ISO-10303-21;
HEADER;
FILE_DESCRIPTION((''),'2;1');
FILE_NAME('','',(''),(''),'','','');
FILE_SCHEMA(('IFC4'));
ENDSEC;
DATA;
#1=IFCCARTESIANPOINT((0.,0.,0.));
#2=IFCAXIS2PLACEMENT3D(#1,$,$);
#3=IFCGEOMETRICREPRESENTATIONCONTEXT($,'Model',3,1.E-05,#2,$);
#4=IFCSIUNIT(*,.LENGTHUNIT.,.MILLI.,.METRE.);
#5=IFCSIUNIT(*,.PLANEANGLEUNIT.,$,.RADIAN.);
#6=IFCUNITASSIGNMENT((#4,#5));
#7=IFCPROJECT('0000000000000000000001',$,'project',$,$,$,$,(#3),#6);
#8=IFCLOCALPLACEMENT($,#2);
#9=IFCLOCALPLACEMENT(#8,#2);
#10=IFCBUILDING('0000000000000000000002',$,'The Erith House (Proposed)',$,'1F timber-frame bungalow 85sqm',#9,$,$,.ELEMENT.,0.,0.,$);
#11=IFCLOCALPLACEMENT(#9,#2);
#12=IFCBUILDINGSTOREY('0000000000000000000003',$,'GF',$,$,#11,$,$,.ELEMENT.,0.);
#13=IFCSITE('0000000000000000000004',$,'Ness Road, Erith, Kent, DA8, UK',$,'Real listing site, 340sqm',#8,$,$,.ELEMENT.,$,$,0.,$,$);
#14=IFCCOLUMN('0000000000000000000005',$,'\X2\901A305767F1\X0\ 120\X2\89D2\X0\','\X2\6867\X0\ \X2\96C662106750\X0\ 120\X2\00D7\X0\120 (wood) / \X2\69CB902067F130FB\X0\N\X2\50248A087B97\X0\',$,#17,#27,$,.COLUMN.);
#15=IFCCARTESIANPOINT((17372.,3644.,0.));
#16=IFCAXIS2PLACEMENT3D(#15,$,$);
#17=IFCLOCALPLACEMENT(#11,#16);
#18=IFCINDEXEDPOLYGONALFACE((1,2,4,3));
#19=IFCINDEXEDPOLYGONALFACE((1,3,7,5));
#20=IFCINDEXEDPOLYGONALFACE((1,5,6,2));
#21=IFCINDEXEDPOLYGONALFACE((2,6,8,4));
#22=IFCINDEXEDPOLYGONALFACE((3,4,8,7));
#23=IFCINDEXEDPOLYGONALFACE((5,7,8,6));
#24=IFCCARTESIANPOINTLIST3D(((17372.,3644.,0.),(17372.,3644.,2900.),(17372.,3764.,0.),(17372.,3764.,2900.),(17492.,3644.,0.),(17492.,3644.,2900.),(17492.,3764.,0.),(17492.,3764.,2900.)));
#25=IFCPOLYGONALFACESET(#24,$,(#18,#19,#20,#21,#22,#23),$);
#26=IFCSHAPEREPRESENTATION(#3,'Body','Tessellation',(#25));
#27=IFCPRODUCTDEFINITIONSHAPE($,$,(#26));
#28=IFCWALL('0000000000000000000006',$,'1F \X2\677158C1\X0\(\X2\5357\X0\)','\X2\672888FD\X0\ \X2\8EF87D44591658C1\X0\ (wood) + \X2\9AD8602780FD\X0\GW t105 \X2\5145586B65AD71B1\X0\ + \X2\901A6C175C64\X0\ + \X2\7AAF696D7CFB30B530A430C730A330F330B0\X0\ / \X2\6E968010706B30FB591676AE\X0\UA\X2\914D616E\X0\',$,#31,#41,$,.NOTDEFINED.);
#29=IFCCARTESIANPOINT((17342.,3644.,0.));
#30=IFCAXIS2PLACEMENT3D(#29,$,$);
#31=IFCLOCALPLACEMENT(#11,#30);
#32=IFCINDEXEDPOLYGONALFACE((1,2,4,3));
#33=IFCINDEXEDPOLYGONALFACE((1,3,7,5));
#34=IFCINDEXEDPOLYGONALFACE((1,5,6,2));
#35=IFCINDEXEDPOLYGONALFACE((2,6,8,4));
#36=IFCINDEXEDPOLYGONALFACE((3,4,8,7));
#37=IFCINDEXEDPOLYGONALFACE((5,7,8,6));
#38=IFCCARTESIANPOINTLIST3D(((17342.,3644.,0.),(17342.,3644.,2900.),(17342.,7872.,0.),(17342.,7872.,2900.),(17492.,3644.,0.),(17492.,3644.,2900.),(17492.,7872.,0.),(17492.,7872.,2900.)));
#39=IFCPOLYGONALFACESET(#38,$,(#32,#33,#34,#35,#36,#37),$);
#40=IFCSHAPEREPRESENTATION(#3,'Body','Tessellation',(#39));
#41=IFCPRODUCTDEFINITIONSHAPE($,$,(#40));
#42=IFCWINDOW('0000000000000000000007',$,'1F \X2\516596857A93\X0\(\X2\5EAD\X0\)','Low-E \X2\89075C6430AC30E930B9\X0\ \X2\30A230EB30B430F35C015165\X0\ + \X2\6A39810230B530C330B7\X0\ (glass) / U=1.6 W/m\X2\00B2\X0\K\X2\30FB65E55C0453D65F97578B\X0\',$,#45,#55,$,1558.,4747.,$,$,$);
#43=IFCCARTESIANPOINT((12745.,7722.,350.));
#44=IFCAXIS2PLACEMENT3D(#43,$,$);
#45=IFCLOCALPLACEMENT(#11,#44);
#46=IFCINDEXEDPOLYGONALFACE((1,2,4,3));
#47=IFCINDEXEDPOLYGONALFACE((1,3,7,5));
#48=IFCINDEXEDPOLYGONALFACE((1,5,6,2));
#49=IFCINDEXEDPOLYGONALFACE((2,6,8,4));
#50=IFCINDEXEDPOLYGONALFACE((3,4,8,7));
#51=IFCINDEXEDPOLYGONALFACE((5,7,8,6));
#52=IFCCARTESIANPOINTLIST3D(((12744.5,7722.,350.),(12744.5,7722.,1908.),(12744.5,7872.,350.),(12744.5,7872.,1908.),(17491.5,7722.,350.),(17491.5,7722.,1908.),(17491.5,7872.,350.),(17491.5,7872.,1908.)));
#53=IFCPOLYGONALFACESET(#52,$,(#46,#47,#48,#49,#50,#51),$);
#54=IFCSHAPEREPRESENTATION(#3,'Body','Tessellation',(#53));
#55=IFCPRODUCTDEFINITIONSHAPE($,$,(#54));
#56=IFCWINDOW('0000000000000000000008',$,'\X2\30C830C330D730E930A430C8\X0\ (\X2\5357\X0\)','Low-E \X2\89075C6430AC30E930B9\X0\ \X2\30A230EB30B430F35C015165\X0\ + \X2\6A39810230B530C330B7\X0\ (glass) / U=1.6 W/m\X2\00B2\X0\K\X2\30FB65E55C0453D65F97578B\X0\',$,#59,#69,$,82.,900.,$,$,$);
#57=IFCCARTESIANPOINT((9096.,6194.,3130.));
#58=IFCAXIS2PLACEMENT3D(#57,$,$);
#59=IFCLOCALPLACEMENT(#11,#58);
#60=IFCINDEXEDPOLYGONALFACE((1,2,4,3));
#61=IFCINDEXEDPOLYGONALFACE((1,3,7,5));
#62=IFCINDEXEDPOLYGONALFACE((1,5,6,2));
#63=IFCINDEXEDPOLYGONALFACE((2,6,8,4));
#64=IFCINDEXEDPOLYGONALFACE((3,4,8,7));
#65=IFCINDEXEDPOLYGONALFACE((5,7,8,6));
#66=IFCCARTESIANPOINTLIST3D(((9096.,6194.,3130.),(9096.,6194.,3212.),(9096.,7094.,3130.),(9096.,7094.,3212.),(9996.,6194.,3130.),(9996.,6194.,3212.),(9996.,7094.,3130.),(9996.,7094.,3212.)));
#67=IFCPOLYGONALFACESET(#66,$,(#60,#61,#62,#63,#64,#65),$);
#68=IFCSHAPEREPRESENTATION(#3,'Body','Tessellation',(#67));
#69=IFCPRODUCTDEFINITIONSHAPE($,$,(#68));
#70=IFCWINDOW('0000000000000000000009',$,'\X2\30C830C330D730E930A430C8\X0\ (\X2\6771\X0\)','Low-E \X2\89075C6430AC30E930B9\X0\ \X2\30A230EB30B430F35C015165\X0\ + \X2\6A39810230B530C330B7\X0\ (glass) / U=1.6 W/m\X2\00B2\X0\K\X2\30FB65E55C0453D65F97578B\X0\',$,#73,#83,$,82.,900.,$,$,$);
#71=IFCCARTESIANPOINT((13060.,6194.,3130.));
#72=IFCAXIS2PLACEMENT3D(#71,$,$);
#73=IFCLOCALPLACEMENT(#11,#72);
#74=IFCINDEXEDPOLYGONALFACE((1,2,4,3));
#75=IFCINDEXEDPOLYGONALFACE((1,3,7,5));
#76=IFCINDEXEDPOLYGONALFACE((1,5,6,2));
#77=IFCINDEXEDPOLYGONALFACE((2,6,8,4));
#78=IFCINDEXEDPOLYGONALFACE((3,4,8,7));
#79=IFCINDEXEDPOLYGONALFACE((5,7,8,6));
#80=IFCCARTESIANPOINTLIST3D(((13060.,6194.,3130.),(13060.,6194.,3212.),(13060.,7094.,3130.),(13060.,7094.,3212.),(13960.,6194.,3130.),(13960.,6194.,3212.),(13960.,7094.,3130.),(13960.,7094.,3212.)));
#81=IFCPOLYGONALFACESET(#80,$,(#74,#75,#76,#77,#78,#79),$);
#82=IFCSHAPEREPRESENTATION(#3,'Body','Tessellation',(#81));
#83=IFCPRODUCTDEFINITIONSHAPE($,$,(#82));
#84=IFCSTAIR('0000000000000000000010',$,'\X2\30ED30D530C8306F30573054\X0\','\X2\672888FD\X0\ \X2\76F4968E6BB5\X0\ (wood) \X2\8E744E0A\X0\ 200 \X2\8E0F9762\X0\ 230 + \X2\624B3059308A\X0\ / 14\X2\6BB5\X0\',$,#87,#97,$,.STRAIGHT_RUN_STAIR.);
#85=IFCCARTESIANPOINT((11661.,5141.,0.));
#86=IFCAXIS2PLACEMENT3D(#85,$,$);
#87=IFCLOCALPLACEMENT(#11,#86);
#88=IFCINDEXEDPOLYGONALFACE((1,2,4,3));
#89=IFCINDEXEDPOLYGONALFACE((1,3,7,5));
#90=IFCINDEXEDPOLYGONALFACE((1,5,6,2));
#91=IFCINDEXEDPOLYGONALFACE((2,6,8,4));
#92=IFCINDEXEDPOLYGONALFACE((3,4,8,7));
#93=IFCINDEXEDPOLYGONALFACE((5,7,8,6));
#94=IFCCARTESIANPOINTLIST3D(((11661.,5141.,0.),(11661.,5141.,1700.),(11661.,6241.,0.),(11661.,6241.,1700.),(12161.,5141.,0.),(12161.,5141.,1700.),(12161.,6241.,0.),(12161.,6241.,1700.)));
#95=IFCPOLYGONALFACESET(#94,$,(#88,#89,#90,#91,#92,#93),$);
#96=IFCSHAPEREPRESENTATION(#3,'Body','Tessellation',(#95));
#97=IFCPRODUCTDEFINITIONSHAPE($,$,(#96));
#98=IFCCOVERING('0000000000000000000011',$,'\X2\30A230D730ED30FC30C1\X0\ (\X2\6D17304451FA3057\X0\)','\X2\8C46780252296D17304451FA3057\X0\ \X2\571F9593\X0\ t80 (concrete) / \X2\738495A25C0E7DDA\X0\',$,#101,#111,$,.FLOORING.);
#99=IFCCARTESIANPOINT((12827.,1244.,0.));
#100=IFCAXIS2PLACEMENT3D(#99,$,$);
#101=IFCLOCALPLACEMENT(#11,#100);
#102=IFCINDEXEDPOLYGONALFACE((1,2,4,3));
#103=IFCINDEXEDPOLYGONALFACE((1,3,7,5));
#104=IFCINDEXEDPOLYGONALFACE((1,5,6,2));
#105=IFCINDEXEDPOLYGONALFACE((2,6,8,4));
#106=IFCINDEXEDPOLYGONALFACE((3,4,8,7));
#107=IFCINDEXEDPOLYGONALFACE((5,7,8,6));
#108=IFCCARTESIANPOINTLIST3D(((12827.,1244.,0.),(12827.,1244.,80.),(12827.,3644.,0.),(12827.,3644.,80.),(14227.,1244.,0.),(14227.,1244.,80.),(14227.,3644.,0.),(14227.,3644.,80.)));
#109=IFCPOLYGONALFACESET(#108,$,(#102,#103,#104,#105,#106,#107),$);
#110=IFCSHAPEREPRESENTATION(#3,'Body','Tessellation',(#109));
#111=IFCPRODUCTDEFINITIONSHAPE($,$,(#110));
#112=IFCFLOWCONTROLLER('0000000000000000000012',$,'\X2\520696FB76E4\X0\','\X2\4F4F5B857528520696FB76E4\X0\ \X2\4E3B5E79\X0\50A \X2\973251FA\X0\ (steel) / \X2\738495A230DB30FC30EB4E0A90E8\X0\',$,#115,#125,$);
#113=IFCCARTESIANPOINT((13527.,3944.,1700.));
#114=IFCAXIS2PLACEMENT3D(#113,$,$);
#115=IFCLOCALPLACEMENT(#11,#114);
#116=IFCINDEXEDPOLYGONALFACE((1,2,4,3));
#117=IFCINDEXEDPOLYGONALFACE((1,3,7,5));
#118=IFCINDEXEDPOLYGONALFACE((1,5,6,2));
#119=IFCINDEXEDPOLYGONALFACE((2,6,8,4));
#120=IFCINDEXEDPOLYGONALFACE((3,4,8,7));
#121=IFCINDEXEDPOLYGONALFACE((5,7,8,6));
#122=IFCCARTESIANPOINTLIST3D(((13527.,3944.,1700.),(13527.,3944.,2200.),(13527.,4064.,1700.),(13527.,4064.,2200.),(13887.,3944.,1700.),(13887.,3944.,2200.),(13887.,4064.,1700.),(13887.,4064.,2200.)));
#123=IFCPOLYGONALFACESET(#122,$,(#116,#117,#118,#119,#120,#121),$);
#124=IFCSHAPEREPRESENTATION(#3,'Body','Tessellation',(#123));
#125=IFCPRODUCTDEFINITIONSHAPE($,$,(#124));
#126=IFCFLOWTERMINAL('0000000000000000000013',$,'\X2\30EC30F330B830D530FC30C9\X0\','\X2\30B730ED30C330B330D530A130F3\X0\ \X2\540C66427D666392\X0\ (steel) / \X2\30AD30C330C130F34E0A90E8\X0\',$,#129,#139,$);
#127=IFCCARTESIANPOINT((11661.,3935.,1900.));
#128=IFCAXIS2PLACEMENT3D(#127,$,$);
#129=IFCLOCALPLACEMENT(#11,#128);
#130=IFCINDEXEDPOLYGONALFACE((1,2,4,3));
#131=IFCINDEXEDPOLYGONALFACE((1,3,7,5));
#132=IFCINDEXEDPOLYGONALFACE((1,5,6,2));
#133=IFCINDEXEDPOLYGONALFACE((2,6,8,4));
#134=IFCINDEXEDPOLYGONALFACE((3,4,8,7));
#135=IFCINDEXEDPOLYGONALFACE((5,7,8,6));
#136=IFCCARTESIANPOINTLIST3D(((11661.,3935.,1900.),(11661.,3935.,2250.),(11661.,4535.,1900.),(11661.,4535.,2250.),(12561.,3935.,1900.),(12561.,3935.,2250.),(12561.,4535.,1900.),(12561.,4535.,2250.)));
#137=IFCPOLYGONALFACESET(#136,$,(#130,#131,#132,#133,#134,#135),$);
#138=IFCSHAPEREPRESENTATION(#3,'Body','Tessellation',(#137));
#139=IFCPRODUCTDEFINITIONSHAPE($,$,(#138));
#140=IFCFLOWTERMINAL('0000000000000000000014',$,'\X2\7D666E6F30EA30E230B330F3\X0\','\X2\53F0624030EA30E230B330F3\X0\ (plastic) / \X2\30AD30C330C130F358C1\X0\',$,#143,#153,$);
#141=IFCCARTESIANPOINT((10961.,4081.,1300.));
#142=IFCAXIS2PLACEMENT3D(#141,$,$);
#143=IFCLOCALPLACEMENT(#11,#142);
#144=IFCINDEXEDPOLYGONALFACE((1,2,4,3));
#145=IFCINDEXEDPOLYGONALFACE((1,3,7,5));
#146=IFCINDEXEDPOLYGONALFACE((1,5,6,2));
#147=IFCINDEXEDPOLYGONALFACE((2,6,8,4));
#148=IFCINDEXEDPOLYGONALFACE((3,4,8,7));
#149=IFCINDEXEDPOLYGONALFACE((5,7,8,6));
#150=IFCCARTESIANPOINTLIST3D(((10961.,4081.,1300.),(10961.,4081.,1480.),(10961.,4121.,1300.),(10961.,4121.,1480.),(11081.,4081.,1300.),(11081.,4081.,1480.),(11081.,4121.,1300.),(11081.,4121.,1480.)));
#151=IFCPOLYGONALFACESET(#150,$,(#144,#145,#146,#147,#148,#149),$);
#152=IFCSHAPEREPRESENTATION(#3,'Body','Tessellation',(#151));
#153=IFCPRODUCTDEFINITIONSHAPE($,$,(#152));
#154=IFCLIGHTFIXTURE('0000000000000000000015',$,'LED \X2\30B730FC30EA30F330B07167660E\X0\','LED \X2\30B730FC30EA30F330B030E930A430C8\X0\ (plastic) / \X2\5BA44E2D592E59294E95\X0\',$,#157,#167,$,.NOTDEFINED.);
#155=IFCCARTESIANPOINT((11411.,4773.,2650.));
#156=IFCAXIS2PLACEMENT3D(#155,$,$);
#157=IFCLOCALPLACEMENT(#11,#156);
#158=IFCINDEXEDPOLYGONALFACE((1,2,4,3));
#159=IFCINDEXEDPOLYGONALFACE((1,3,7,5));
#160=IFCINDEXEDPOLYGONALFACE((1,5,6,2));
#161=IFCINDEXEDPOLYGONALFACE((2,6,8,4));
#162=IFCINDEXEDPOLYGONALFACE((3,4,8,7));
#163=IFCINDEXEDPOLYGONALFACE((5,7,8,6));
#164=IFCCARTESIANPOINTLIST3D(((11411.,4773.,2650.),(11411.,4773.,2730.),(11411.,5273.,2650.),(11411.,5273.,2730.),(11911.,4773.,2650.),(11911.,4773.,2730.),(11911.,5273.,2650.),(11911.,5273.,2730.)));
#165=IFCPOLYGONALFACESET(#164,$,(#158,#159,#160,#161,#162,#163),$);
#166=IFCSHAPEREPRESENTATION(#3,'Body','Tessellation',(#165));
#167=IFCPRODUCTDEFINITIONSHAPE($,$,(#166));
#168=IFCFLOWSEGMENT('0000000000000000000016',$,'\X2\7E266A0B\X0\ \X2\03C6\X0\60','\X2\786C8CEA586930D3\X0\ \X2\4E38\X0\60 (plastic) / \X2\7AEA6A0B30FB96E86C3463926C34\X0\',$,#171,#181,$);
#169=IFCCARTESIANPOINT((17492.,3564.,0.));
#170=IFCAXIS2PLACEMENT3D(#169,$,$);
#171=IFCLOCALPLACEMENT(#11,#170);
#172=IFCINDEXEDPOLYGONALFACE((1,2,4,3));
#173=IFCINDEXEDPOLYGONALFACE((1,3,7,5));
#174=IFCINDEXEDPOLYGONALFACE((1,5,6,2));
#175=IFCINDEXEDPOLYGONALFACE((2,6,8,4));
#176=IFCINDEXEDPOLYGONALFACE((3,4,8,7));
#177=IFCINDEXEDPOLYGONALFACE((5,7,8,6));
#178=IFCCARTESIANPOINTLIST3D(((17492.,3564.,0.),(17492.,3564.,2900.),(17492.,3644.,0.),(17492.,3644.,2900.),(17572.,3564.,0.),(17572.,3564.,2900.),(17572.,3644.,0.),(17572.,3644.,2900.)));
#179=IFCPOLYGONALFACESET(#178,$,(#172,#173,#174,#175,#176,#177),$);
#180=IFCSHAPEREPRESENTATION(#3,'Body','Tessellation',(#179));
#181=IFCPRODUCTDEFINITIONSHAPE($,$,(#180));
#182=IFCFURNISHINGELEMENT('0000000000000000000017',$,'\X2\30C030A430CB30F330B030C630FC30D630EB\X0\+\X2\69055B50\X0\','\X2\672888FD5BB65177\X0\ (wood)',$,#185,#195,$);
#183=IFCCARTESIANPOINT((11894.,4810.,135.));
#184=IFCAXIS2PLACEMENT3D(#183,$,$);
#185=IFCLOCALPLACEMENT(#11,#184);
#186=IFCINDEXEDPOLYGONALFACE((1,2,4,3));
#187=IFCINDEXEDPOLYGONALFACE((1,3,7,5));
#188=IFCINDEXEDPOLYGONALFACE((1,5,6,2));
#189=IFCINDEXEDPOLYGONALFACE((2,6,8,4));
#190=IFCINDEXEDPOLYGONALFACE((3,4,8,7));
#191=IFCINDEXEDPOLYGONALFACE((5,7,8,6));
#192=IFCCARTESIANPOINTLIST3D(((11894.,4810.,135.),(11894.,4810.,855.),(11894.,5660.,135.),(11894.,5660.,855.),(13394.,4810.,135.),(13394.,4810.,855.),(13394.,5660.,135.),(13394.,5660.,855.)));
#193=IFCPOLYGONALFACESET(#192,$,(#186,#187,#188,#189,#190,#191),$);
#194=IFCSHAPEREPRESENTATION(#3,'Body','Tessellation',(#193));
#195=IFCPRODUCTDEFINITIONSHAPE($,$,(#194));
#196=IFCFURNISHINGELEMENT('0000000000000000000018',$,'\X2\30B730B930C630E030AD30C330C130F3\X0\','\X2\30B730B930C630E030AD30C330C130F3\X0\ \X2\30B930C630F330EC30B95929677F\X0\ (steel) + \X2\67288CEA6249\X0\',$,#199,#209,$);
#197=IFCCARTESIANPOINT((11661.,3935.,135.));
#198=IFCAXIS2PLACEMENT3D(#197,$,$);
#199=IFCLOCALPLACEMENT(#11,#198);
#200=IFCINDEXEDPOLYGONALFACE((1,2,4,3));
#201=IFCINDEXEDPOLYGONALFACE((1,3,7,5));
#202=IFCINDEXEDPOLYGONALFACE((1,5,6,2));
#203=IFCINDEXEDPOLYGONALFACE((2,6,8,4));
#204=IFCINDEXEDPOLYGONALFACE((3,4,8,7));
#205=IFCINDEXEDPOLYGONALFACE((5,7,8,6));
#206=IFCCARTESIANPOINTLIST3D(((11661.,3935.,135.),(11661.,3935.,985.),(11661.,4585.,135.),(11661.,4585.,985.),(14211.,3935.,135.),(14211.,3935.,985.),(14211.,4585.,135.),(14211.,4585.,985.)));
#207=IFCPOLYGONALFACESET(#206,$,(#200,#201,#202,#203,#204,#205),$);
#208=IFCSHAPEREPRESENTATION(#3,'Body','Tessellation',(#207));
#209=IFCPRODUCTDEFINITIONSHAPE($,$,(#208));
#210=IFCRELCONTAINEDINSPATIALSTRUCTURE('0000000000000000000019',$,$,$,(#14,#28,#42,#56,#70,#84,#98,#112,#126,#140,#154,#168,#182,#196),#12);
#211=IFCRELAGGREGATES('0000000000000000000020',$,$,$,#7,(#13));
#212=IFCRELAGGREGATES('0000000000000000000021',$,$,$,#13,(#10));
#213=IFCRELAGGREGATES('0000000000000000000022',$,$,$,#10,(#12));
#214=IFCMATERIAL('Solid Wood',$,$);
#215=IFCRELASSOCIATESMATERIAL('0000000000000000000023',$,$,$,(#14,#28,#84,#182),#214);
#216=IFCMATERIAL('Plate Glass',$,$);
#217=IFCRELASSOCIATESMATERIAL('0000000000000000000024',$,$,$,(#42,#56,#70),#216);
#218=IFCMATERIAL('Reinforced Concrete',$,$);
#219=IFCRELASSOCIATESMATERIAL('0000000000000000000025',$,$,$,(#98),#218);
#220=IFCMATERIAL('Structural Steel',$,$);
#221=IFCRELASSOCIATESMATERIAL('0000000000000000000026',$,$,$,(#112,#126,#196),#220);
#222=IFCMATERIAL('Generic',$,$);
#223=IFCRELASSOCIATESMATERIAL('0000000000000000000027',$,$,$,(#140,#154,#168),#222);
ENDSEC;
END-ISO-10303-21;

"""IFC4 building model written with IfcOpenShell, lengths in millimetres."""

from ifc_helpers import new_model, si_unit, frame, frame_2d, origin, place, context, project, spatial, rectangle, extrude, material, element, fill, save


model = new_model("IFC4")

# Units and contexts
model_context = context("Model", 3, precision=1e-05, world=origin())
ifc_project = project(units=[si_unit("LENGTHUNIT", "METRE", prefix="MILLI"), si_unit("PLANEANGLEUNIT", "RADIAN")], contexts=[model_context])

# Site, building, storey
site_placement = place(None, origin())
site = spatial("IfcSite", under=ifc_project, at=site_placement, Name="Ness Road, Erith, Kent, DA8, UK", ObjectType="Real listing site, 340sqm", CompositionType="ELEMENT", RefElevation=0.0)
building_placement = place(site_placement, origin())
building = spatial("IfcBuilding", under=site, at=building_placement, Name="The Erith House (Proposed)", ObjectType="1F timber-frame bungalow 85sqm", CompositionType="ELEMENT", ElevationOfRefHeight=0.0, ElevationOfTerrain=0.0)
storey_placement = place(building_placement, origin())
storey = spatial("IfcBuildingStorey", under=building, at=storey_placement, Name="GF", CompositionType="ELEMENT", Elevation=0.0)

# Column
ifc_material_1 = material(Name="Solid Wood")
column_1_placement = place(storey_placement, frame((17372.0, 3644.0, 0.0)))
element("IfcColumn", 1, at=column_1_placement, inside=storey, material=ifc_material_1, Name="通し柱 120角", Description="桧 集成材 120×120 (wood) / 構造柱・N値計算", PredefinedType="COLUMN", context=model_context, shape_type="SweptSolid", body=[
    extrude(rectangle(XDim=120.0, YDim=120.0, at=frame_2d((60.0, 60.0))), frame((17372.0, 3644.0, 0.0)), (0.0, 0.0, 1.0), 2900.0),
])

# Wall, opening, window
wall_1_placement = place(storey_placement, frame((17342.0, 3644.0, 0.0)))
wall_1 = element("IfcWall", 2, at=wall_1_placement, inside=storey, material=ifc_material_1, Name="1F 東壁(南)", Description="木製 軸組外壁 (wood) + 高性能GW t105 充填断熱 + 通気層 + 窯業系サイディング / 準耐火・外皮UA配慮", PredefinedType="NOTDEFINED", context=model_context, shape_type="SweptSolid", body=[
    extrude(rectangle(XDim=150.0, YDim=4228.0, at=frame_2d((75.0, 2114.0))), frame((17342.0, 3644.0, 0.0)), (0.0, 0.0, 1.0), 2900.0),
])
opening_1_placement = place(storey_placement, frame((12745.0, 7722.0, 350.0)))
opening_1 = element("IfcOpeningElement", 3, at=opening_1_placement, cuts=wall_1, PredefinedType="NOTDEFINED", context=model_context, shape_type="SweptSolid", body=[
    extrude(rectangle(XDim=4747.0, YDim=150.0, at=frame_2d((2373.0, 75.0))), frame((12745.0, 7722.0, 350.0)), (0.0, 0.0, 1.0), 1558.0),
])
ifc_material_2 = material(Name="Plate Glass")
window_1_placement = place(storey_placement, frame((12745.0, 7722.0, 350.0)))
window_1 = element("IfcWindow", 4, at=window_1_placement, inside=storey, material=ifc_material_2, Name="1F 入隅窓(庭)", Description="Low-E 複層ガラス アルゴン封入 + 樹脂サッシ (glass) / U=1.6 W/m²K・日射取得型", OverallHeight=1558.0, OverallWidth=4747.0, context=model_context, shape_type="SweptSolid", body=[
    extrude(rectangle(XDim=4747.0, YDim=150.0, at=frame_2d((2373.0, 75.0))), frame((12745.0, 7722.0, 350.0)), (0.0, 0.0, 1.0), 1558.0),
])
fill(opening_1, window_1)

# Windows
window_2_placement = place(storey_placement, frame((9096.0, 6194.0, 3130.0)))
element("IfcWindow", 5, at=window_2_placement, inside=storey, material=ifc_material_2, Name="トップライト (南)", Description="Low-E 複層ガラス アルゴン封入 + 樹脂サッシ (glass) / U=1.6 W/m²K・日射取得型", OverallHeight=82.0, OverallWidth=900.0, context=model_context, shape_type="SweptSolid", body=[
    extrude(rectangle(XDim=900.0, YDim=900.0, at=frame_2d((450.0, 450.0))), frame((9096.0, 6194.0, 3130.0)), (0.0, 0.0, 1.0), 82.0),
])
window_3_placement = place(storey_placement, frame((13060.0, 6194.0, 3130.0)))
element("IfcWindow", 6, at=window_3_placement, inside=storey, material=ifc_material_2, Name="トップライト (東)", Description="Low-E 複層ガラス アルゴン封入 + 樹脂サッシ (glass) / U=1.6 W/m²K・日射取得型", OverallHeight=82.0, OverallWidth=900.0, context=model_context, shape_type="SweptSolid", body=[
    extrude(rectangle(XDim=900.0, YDim=900.0, at=frame_2d((450.0, 450.0))), frame((13060.0, 6194.0, 3130.0)), (0.0, 0.0, 1.0), 82.0),
])

# Stair
stair_placement = place(storey_placement, frame((11661.0, 5141.0, 0.0)))
element("IfcStair", 7, at=stair_placement, inside=storey, material=ifc_material_1, Name="ロフトはしご", Description="木製 直階段 (wood) 蹴上 200 踏面 230 + 手すり / 14段", PredefinedType="STRAIGHT_RUN_STAIR", context=model_context, shape_type="SweptSolid", body=[
    extrude(rectangle(XDim=500.0, YDim=1100.0, at=frame_2d((250.0, 550.0))), frame((11661.0, 5141.0, 0.0)), (0.0, 0.0, 1.0), 1700.0),
])

# Covering
ifc_material_3 = material(Name="Reinforced Concrete")
covering_placement = place(storey_placement, frame((12827.0, 1244.0, 0.0)))
element("IfcCovering", 8, at=covering_placement, inside=storey, material=ifc_material_3, Name="アプローチ (洗い出し)", Description="豆砂利洗い出し 土間 t80 (concrete) / 玄関導線", PredefinedType="FLOORING", context=model_context, shape_type="SweptSolid", body=[
    extrude(rectangle(XDim=1400.0, YDim=2400.0, at=frame_2d((700.0, 1200.0))), frame((12827.0, 1244.0, 0.0)), (0.0, 0.0, 1.0), 80.0),
])

# Flow controller
ifc_material_4 = material(Name="Structural Steel")
flow_controller_placement = place(storey_placement, frame((13527.0, 3944.0, 1700.0)))
element("IfcFlowController", 9, at=flow_controller_placement, inside=storey, material=ifc_material_4, Name="分電盤", Description="住宅用分電盤 主幹50A 露出 (steel) / 玄関ホール上部", context=model_context, shape_type="SweptSolid", body=[
    extrude(rectangle(XDim=360.0, YDim=120.0, at=frame_2d((180.0, 60.0))), frame((13527.0, 3944.0, 1700.0)), (0.0, 0.0, 1.0), 500.0),
])

# Flow terminals
flow_terminal_1_placement = place(storey_placement, frame((11661.0, 3935.0, 1900.0)))
element("IfcFlowTerminal", 10, at=flow_terminal_1_placement, inside=storey, material=ifc_material_4, Name="レンジフード", Description="シロッコファン 同時給排 (steel) / キッチン上部", context=model_context, shape_type="SweptSolid", body=[
    extrude(rectangle(XDim=900.0, YDim=600.0, at=frame_2d((450.0, 300.0))), frame((11661.0, 3935.0, 1900.0)), (0.0, 0.0, 1.0), 350.0),
])
ifc_material_5 = material(Name="Generic")
flow_terminal_2_placement = place(storey_placement, frame((10961.0, 4081.0, 1300.0)))
element("IfcFlowTerminal", 11, at=flow_terminal_2_placement, inside=storey, material=ifc_material_5, Name="給湯リモコン", Description="台所リモコン (plastic) / キッチン壁", context=model_context, shape_type="SweptSolid", body=[
    extrude(rectangle(XDim=120.0, YDim=40.0, at=frame_2d((60.0, 20.0))), frame((10961.0, 4081.0, 1300.0)), (0.0, 0.0, 1.0), 180.0),
])

# Light fixture
light_fixture_placement = place(storey_placement, frame((11411.0, 4773.0, 2650.0)))
element("IfcLightFixture", 12, at=light_fixture_placement, inside=storey, material=ifc_material_5, Name="LED シーリング照明", Description="LED シーリングライト (plastic) / 室中央天井", PredefinedType="NOTDEFINED", context=model_context, shape_type="SweptSolid", body=[
    extrude(rectangle(XDim=500.0, YDim=500.0, at=frame_2d((250.0, 250.0))), frame((11411.0, 4773.0, 2650.0)), (0.0, 0.0, 1.0), 80.0),
])

# Flow segment
flow_segment_placement = place(storey_placement, frame((17492.0, 3564.0, 0.0)))
element("IfcFlowSegment", 13, at=flow_segment_placement, inside=storey, material=ifc_material_5, Name="縦樋 φ60", Description="硬質塩ビ 丸60 (plastic) / 竪樋・雨水排水", context=model_context, shape_type="SweptSolid", body=[
    extrude(rectangle(XDim=80.0, YDim=80.0, at=frame_2d((40.0, 40.0))), frame((17492.0, 3564.0, 0.0)), (0.0, 0.0, 1.0), 2900.0),
])

# Furnishing elements
furnishing_1_placement = place(storey_placement, frame((11894.0, 4810.0, 135.0)))
element("IfcFurnishingElement", 14, at=furnishing_1_placement, inside=storey, material=ifc_material_1, Name="ダイニングテーブル+椅子", Description="木製家具 (wood)", context=model_context, shape_type="SweptSolid", body=[
    extrude(rectangle(XDim=1500.0, YDim=850.0, at=frame_2d((750.0, 425.0))), frame((11894.0, 4810.0, 135.0)), (0.0, 0.0, 1.0), 720.0),
])
furnishing_2_placement = place(storey_placement, frame((11661.0, 3935.0, 135.0)))
element("IfcFurnishingElement", 15, at=furnishing_2_placement, inside=storey, material=ifc_material_4, Name="システムキッチン", Description="システムキッチン ステンレス天板 (steel) + 木質扉", context=model_context, shape_type="SweptSolid", body=[
    extrude(rectangle(XDim=2550.0, YDim=650.0, at=frame_2d((1275.0, 325.0))), frame((11661.0, 3935.0, 135.0)), (0.0, 0.0, 1.0), 850.0),
])

save(model, "model.ifc")
